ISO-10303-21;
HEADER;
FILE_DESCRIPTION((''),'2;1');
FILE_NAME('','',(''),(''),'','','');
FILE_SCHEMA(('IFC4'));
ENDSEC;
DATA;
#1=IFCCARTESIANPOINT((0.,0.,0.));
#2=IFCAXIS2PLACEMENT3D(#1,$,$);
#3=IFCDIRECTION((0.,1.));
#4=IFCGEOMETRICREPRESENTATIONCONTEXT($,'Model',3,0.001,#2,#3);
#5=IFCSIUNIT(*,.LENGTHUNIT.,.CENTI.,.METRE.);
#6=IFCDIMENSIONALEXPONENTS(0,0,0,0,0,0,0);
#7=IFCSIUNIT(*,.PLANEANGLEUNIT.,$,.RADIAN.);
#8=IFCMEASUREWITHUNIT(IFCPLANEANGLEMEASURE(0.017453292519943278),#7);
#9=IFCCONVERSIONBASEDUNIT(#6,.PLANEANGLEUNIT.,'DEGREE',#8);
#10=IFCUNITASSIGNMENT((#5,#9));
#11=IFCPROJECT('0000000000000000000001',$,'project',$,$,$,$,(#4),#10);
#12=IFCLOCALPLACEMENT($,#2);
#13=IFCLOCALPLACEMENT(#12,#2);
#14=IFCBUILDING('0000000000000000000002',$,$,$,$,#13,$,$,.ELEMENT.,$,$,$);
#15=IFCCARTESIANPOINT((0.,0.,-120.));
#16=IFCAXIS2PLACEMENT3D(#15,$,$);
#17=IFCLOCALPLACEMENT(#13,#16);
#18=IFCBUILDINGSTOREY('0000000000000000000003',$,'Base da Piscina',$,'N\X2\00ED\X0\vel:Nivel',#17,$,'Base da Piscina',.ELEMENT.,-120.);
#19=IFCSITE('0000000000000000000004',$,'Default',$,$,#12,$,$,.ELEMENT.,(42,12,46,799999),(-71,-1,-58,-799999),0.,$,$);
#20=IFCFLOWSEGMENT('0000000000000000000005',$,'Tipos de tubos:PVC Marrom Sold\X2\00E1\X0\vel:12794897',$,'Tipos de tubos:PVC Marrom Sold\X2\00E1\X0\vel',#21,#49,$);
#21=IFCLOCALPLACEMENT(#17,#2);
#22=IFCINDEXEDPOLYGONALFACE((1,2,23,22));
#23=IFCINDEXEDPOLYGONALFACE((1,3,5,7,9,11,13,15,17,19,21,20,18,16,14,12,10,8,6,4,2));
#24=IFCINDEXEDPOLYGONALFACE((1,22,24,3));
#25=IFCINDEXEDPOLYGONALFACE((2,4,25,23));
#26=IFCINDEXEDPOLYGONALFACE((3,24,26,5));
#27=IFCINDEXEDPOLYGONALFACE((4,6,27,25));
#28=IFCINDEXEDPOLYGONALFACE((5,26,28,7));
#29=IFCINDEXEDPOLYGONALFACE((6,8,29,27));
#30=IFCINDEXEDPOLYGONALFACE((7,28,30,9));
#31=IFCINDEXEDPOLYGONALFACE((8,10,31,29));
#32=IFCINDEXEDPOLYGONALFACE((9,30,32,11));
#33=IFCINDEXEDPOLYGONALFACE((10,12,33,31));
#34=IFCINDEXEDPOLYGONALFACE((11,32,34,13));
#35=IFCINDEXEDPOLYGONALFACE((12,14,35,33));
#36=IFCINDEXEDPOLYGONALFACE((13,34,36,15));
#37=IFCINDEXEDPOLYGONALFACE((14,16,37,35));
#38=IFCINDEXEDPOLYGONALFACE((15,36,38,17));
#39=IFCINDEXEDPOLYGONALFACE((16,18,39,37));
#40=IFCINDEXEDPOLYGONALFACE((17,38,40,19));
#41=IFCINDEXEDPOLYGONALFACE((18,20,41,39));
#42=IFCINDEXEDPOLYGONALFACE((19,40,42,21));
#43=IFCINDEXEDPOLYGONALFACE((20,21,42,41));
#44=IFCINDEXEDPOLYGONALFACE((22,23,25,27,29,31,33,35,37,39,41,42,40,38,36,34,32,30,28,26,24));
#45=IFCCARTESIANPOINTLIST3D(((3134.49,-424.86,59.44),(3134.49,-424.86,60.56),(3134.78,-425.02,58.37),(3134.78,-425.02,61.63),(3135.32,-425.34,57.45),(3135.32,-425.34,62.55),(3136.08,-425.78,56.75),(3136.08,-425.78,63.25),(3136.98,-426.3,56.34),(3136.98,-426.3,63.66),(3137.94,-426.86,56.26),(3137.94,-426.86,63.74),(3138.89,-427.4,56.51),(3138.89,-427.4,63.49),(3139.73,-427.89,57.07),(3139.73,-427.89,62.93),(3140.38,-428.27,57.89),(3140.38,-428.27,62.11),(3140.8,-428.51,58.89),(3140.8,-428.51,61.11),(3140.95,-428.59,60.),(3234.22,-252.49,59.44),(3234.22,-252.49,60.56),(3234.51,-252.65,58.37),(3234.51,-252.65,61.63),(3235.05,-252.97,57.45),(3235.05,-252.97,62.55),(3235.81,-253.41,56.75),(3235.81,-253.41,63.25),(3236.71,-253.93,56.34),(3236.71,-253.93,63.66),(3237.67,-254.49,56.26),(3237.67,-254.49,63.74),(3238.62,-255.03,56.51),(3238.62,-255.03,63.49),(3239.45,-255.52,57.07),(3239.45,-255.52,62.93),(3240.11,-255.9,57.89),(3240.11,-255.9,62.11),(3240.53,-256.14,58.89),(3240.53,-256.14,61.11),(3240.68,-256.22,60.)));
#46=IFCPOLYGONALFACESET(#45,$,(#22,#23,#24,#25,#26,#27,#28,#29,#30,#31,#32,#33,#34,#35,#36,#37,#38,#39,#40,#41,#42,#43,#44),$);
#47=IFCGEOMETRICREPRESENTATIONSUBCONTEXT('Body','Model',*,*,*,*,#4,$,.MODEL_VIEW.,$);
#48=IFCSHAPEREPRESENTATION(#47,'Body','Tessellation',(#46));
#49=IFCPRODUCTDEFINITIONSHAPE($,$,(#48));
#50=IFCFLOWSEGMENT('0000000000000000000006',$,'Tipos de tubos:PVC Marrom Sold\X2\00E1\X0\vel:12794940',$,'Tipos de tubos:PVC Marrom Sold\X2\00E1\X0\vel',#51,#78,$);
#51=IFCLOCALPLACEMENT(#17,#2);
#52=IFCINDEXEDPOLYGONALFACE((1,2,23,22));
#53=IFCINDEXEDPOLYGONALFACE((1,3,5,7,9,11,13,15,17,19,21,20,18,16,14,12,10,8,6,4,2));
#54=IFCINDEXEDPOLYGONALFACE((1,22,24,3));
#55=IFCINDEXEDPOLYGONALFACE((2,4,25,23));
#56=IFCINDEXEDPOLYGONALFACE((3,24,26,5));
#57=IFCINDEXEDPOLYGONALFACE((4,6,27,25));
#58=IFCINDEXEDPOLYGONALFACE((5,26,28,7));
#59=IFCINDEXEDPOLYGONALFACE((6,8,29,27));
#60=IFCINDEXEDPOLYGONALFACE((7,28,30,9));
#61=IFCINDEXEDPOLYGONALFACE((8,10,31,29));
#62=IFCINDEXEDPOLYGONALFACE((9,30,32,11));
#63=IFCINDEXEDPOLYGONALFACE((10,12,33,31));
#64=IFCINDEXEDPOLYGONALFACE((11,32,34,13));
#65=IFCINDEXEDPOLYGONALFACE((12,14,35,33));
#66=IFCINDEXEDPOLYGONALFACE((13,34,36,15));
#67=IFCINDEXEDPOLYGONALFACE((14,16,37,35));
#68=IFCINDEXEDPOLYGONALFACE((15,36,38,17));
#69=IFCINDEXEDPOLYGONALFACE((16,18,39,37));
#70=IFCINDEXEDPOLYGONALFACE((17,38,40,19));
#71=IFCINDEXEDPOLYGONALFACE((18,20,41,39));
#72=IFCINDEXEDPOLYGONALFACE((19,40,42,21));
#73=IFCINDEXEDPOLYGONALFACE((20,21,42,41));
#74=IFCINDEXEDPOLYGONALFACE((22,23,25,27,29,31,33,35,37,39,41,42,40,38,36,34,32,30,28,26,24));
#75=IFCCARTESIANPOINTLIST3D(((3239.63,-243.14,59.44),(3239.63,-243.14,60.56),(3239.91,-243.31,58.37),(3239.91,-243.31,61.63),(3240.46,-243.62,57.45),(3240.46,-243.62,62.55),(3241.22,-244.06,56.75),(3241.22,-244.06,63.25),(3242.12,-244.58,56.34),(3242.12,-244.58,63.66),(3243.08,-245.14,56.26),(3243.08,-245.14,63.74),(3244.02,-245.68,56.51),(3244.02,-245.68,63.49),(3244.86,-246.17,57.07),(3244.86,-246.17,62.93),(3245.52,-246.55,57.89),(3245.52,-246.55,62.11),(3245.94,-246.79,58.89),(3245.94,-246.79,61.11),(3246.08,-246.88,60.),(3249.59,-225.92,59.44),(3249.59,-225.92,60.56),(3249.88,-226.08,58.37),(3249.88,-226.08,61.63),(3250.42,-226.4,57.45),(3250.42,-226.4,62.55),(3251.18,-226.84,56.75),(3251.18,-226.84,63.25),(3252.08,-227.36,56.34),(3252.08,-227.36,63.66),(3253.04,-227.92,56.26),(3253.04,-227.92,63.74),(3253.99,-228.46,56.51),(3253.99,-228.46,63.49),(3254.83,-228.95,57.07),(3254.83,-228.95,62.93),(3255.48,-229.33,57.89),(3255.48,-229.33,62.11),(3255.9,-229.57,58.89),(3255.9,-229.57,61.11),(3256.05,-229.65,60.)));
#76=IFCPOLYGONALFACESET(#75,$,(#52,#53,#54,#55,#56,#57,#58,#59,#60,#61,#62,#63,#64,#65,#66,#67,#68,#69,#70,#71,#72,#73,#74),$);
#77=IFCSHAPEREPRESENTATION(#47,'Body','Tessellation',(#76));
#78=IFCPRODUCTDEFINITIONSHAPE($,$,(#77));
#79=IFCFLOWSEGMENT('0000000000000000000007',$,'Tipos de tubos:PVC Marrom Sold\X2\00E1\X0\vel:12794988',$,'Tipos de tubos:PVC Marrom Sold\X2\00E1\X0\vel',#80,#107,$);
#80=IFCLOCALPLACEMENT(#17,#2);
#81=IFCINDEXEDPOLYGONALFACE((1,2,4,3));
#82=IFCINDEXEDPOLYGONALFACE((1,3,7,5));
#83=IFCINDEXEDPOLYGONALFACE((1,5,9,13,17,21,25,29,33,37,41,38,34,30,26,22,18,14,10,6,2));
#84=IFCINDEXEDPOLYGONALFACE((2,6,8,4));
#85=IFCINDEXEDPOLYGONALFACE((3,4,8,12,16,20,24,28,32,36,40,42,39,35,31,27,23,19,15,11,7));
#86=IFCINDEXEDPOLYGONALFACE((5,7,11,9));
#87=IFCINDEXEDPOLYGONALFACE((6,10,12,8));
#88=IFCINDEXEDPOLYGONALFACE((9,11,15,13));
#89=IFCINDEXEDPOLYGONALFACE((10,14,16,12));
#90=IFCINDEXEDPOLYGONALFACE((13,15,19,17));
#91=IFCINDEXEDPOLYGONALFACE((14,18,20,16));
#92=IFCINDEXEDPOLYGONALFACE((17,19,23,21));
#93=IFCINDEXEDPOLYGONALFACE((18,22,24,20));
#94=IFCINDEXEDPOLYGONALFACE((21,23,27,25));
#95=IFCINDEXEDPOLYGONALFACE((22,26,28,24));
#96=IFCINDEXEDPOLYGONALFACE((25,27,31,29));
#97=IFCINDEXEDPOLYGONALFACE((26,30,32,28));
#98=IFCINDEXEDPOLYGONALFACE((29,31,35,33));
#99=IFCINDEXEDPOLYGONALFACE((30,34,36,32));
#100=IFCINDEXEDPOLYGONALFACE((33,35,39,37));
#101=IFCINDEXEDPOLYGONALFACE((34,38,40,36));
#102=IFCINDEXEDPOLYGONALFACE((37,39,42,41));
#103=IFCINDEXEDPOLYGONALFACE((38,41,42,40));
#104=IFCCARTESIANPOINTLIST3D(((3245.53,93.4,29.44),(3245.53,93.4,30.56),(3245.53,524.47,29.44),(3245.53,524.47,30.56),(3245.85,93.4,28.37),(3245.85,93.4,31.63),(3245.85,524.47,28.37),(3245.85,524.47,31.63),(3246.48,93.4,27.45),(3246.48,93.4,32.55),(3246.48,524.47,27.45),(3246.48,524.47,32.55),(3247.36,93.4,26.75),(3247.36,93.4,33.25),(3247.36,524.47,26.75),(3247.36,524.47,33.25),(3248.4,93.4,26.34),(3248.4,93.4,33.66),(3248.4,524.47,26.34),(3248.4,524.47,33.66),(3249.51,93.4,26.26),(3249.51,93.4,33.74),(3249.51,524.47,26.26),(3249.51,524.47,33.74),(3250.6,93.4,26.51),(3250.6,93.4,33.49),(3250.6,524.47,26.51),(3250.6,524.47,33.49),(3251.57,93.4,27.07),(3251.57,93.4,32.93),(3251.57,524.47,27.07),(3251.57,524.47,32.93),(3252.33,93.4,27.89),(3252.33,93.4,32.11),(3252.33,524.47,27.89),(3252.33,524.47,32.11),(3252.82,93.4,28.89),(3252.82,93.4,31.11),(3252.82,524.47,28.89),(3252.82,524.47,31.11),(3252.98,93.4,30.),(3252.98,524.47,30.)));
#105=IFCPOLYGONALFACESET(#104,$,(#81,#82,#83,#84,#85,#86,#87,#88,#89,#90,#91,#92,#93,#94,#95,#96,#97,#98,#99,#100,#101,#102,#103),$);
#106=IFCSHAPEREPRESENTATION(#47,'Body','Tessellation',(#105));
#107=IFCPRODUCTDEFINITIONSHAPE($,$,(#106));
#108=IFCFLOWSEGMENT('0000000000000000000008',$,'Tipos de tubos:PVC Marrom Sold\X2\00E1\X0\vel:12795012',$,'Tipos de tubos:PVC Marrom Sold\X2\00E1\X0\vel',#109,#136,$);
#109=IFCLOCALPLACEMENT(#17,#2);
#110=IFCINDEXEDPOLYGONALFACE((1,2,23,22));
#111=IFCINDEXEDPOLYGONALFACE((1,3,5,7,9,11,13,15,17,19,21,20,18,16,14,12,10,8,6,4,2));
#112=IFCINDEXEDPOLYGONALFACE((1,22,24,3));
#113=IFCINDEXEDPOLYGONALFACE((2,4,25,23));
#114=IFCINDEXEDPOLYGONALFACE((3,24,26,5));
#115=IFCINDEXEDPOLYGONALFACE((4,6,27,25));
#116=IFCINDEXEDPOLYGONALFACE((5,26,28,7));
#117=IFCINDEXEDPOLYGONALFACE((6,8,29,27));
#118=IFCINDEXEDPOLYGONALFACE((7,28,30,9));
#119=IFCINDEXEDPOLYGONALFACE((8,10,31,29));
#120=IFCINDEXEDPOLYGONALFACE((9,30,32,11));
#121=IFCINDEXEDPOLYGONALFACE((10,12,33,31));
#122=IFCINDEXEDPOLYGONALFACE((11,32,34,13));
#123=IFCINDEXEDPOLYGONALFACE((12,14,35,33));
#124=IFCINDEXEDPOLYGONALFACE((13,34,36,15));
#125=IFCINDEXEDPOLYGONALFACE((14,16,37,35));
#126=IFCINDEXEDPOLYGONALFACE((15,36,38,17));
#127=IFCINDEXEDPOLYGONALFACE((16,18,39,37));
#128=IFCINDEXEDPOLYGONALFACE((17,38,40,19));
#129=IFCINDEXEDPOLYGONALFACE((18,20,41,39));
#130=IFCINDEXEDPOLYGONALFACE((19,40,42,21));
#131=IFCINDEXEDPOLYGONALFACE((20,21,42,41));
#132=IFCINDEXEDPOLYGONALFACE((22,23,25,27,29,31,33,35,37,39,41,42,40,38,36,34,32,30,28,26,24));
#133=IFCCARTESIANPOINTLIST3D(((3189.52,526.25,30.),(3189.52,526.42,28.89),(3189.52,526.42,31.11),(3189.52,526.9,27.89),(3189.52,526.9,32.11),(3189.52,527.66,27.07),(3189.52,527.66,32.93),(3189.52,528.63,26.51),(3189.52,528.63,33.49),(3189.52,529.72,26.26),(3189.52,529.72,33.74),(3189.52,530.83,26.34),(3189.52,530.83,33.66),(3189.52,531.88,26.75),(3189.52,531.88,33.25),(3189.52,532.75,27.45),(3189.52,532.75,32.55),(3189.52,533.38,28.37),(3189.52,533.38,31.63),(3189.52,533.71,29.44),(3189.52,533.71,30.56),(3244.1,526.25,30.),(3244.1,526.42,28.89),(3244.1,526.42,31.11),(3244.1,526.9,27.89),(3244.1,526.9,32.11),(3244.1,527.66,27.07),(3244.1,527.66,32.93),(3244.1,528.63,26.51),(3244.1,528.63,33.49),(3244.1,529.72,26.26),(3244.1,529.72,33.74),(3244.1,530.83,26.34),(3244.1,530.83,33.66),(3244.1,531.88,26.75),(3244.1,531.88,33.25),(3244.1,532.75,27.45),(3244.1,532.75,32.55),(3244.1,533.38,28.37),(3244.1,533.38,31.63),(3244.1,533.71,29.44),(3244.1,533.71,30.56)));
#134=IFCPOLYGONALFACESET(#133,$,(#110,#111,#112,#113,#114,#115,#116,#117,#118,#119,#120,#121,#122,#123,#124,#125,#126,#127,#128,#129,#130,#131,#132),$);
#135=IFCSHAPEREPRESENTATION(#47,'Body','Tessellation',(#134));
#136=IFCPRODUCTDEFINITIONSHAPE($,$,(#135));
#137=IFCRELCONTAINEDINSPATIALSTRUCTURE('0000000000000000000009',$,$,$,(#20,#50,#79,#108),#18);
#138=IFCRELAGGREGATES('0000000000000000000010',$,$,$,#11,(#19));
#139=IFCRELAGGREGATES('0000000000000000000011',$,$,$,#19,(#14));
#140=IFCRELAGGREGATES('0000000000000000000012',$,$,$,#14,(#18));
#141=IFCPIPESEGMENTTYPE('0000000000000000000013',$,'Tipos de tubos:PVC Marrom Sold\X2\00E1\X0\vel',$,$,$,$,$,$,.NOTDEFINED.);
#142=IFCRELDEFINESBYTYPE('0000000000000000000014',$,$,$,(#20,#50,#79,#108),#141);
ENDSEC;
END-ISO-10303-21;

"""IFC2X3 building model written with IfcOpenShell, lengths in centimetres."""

from ifc_helpers import new_model, entity, si_unit, converted_unit, direction, frame, frame_2d, origin, origin_2d_with_axis, place, context, subcontext, project, spatial, circle, extrude, type_object, element, save


model = new_model("IFC2X3")

# Units and contexts
model_context = context("Model", 3, precision=0.001, world=origin(), true_north=direction((0.0, 1.0)))
body_context = subcontext(model_context, "Body", "Model", "MODEL_VIEW")
ifc_project = project(units=[si_unit("LENGTHUNIT", "METRE", prefix="CENTI"), converted_unit("PLANEANGLEUNIT", "DEGREE", entity("IfcPlaneAngleMeasure", 0.017453292519943278), si_unit("PLANEANGLEUNIT", "RADIAN"), dimensions=[0, 0, 0, 0, 0, 0, 0])], contexts=[model_context])

# Site, building, storey
site_placement = place(None, origin())
site = spatial("IfcSite", under=ifc_project, at=site_placement, Name="Default", CompositionType="ELEMENT", RefLatitude=(42, 12, 46, 799999), RefLongitude=(-71, -1, -58, -799999), RefElevation=0.0)
building_placement = place(site_placement, origin())
building = spatial("IfcBuilding", under=site, at=building_placement, CompositionType="ELEMENT")
storey_placement = place(building_placement, frame((0.0, 0.0, -120.0)))
storey = spatial("IfcBuildingStorey", under=building, at=storey_placement, Name="Base da Piscina", ObjectType="Nível:Nivel", LongName="Base da Piscina", CompositionType="ELEMENT", Elevation=-120.0)

# Flow segments
pipe_segment_type = type_object("IfcPipeSegmentType", Name="Tipos de tubos:PVC Marrom Soldável", PredefinedType="NOTDEFINED")
flow_segment_1_placement = place(storey_placement, origin())
element("IfcFlowSegment", 1, at=flow_segment_1_placement, inside=storey, type_object=pipe_segment_type, Name="Tipos de tubos:PVC Marrom Soldável:12794897", ObjectType="Tipos de tubos:PVC Marrom Soldável", context=body_context, shape_type="SweptSolid", body=[
    extrude(circle(Radius=3.75, at=frame_2d((0.0, 0.0), x_axis=(1.0, 0.0))), frame((3137.7, -426.72, 60.0), z_axis=(0.50079, 0.865569, 0.0), x_axis=(0.865569, -0.50079, 0.0)), (0.0, 0.0, 1.0), 199.14),
])
flow_segment_2_placement = place(storey_placement, origin())
element("IfcFlowSegment", 2, at=flow_segment_2_placement, inside=storey, type_object=pipe_segment_type, Name="Tipos de tubos:PVC Marrom Soldável:12794940", ObjectType="Tipos de tubos:PVC Marrom Soldável", context=body_context, shape_type="SweptSolid", body=[
    extrude(circle(Radius=3.75, at=frame_2d((0.0, 0.0), x_axis=(1.0, 0.0))), frame((3242.84, -245.0, 60.0), z_axis=(0.50079, 0.865569, 0.0), x_axis=(0.865569, -0.50079, 0.0)), (0.0, 0.0, 1.0), 19.9),
])
flow_segment_3_placement = place(storey_placement, origin())
element("IfcFlowSegment", 3, at=flow_segment_3_placement, inside=storey, type_object=pipe_segment_type, Name="Tipos de tubos:PVC Marrom Soldável:12794988", ObjectType="Tipos de tubos:PVC Marrom Soldável", context=body_context, shape_type="SweptSolid", body=[
    extrude(circle(Radius=3.75, at=origin_2d_with_axis()), frame((3249.23, 93.4, 30.0), z_axis=(0.0, 1.0, 0.0), x_axis=(1.0, 0.0, 0.0)), (0.0, 0.0, 1.0), 431.07),
])
flow_segment_4_placement = place(storey_placement, origin())
element("IfcFlowSegment", 4, at=flow_segment_4_placement, inside=storey, type_object=pipe_segment_type, Name="Tipos de tubos:PVC Marrom Soldável:12795012", ObjectType="Tipos de tubos:PVC Marrom Soldável", context=body_context, shape_type="SweptSolid", body=[
    extrude(circle(Radius=3.75, at=frame_2d((0.0, 0.0), x_axis=(1.0, 0.0))), frame((3189.52, 530.0, 30.0), z_axis=(1.0, 0.0, 0.0), x_axis=(0.0, -1.0, 0.0)), (0.0, 0.0, 1.0), 54.58),
])

save(model, "model.ifc")
